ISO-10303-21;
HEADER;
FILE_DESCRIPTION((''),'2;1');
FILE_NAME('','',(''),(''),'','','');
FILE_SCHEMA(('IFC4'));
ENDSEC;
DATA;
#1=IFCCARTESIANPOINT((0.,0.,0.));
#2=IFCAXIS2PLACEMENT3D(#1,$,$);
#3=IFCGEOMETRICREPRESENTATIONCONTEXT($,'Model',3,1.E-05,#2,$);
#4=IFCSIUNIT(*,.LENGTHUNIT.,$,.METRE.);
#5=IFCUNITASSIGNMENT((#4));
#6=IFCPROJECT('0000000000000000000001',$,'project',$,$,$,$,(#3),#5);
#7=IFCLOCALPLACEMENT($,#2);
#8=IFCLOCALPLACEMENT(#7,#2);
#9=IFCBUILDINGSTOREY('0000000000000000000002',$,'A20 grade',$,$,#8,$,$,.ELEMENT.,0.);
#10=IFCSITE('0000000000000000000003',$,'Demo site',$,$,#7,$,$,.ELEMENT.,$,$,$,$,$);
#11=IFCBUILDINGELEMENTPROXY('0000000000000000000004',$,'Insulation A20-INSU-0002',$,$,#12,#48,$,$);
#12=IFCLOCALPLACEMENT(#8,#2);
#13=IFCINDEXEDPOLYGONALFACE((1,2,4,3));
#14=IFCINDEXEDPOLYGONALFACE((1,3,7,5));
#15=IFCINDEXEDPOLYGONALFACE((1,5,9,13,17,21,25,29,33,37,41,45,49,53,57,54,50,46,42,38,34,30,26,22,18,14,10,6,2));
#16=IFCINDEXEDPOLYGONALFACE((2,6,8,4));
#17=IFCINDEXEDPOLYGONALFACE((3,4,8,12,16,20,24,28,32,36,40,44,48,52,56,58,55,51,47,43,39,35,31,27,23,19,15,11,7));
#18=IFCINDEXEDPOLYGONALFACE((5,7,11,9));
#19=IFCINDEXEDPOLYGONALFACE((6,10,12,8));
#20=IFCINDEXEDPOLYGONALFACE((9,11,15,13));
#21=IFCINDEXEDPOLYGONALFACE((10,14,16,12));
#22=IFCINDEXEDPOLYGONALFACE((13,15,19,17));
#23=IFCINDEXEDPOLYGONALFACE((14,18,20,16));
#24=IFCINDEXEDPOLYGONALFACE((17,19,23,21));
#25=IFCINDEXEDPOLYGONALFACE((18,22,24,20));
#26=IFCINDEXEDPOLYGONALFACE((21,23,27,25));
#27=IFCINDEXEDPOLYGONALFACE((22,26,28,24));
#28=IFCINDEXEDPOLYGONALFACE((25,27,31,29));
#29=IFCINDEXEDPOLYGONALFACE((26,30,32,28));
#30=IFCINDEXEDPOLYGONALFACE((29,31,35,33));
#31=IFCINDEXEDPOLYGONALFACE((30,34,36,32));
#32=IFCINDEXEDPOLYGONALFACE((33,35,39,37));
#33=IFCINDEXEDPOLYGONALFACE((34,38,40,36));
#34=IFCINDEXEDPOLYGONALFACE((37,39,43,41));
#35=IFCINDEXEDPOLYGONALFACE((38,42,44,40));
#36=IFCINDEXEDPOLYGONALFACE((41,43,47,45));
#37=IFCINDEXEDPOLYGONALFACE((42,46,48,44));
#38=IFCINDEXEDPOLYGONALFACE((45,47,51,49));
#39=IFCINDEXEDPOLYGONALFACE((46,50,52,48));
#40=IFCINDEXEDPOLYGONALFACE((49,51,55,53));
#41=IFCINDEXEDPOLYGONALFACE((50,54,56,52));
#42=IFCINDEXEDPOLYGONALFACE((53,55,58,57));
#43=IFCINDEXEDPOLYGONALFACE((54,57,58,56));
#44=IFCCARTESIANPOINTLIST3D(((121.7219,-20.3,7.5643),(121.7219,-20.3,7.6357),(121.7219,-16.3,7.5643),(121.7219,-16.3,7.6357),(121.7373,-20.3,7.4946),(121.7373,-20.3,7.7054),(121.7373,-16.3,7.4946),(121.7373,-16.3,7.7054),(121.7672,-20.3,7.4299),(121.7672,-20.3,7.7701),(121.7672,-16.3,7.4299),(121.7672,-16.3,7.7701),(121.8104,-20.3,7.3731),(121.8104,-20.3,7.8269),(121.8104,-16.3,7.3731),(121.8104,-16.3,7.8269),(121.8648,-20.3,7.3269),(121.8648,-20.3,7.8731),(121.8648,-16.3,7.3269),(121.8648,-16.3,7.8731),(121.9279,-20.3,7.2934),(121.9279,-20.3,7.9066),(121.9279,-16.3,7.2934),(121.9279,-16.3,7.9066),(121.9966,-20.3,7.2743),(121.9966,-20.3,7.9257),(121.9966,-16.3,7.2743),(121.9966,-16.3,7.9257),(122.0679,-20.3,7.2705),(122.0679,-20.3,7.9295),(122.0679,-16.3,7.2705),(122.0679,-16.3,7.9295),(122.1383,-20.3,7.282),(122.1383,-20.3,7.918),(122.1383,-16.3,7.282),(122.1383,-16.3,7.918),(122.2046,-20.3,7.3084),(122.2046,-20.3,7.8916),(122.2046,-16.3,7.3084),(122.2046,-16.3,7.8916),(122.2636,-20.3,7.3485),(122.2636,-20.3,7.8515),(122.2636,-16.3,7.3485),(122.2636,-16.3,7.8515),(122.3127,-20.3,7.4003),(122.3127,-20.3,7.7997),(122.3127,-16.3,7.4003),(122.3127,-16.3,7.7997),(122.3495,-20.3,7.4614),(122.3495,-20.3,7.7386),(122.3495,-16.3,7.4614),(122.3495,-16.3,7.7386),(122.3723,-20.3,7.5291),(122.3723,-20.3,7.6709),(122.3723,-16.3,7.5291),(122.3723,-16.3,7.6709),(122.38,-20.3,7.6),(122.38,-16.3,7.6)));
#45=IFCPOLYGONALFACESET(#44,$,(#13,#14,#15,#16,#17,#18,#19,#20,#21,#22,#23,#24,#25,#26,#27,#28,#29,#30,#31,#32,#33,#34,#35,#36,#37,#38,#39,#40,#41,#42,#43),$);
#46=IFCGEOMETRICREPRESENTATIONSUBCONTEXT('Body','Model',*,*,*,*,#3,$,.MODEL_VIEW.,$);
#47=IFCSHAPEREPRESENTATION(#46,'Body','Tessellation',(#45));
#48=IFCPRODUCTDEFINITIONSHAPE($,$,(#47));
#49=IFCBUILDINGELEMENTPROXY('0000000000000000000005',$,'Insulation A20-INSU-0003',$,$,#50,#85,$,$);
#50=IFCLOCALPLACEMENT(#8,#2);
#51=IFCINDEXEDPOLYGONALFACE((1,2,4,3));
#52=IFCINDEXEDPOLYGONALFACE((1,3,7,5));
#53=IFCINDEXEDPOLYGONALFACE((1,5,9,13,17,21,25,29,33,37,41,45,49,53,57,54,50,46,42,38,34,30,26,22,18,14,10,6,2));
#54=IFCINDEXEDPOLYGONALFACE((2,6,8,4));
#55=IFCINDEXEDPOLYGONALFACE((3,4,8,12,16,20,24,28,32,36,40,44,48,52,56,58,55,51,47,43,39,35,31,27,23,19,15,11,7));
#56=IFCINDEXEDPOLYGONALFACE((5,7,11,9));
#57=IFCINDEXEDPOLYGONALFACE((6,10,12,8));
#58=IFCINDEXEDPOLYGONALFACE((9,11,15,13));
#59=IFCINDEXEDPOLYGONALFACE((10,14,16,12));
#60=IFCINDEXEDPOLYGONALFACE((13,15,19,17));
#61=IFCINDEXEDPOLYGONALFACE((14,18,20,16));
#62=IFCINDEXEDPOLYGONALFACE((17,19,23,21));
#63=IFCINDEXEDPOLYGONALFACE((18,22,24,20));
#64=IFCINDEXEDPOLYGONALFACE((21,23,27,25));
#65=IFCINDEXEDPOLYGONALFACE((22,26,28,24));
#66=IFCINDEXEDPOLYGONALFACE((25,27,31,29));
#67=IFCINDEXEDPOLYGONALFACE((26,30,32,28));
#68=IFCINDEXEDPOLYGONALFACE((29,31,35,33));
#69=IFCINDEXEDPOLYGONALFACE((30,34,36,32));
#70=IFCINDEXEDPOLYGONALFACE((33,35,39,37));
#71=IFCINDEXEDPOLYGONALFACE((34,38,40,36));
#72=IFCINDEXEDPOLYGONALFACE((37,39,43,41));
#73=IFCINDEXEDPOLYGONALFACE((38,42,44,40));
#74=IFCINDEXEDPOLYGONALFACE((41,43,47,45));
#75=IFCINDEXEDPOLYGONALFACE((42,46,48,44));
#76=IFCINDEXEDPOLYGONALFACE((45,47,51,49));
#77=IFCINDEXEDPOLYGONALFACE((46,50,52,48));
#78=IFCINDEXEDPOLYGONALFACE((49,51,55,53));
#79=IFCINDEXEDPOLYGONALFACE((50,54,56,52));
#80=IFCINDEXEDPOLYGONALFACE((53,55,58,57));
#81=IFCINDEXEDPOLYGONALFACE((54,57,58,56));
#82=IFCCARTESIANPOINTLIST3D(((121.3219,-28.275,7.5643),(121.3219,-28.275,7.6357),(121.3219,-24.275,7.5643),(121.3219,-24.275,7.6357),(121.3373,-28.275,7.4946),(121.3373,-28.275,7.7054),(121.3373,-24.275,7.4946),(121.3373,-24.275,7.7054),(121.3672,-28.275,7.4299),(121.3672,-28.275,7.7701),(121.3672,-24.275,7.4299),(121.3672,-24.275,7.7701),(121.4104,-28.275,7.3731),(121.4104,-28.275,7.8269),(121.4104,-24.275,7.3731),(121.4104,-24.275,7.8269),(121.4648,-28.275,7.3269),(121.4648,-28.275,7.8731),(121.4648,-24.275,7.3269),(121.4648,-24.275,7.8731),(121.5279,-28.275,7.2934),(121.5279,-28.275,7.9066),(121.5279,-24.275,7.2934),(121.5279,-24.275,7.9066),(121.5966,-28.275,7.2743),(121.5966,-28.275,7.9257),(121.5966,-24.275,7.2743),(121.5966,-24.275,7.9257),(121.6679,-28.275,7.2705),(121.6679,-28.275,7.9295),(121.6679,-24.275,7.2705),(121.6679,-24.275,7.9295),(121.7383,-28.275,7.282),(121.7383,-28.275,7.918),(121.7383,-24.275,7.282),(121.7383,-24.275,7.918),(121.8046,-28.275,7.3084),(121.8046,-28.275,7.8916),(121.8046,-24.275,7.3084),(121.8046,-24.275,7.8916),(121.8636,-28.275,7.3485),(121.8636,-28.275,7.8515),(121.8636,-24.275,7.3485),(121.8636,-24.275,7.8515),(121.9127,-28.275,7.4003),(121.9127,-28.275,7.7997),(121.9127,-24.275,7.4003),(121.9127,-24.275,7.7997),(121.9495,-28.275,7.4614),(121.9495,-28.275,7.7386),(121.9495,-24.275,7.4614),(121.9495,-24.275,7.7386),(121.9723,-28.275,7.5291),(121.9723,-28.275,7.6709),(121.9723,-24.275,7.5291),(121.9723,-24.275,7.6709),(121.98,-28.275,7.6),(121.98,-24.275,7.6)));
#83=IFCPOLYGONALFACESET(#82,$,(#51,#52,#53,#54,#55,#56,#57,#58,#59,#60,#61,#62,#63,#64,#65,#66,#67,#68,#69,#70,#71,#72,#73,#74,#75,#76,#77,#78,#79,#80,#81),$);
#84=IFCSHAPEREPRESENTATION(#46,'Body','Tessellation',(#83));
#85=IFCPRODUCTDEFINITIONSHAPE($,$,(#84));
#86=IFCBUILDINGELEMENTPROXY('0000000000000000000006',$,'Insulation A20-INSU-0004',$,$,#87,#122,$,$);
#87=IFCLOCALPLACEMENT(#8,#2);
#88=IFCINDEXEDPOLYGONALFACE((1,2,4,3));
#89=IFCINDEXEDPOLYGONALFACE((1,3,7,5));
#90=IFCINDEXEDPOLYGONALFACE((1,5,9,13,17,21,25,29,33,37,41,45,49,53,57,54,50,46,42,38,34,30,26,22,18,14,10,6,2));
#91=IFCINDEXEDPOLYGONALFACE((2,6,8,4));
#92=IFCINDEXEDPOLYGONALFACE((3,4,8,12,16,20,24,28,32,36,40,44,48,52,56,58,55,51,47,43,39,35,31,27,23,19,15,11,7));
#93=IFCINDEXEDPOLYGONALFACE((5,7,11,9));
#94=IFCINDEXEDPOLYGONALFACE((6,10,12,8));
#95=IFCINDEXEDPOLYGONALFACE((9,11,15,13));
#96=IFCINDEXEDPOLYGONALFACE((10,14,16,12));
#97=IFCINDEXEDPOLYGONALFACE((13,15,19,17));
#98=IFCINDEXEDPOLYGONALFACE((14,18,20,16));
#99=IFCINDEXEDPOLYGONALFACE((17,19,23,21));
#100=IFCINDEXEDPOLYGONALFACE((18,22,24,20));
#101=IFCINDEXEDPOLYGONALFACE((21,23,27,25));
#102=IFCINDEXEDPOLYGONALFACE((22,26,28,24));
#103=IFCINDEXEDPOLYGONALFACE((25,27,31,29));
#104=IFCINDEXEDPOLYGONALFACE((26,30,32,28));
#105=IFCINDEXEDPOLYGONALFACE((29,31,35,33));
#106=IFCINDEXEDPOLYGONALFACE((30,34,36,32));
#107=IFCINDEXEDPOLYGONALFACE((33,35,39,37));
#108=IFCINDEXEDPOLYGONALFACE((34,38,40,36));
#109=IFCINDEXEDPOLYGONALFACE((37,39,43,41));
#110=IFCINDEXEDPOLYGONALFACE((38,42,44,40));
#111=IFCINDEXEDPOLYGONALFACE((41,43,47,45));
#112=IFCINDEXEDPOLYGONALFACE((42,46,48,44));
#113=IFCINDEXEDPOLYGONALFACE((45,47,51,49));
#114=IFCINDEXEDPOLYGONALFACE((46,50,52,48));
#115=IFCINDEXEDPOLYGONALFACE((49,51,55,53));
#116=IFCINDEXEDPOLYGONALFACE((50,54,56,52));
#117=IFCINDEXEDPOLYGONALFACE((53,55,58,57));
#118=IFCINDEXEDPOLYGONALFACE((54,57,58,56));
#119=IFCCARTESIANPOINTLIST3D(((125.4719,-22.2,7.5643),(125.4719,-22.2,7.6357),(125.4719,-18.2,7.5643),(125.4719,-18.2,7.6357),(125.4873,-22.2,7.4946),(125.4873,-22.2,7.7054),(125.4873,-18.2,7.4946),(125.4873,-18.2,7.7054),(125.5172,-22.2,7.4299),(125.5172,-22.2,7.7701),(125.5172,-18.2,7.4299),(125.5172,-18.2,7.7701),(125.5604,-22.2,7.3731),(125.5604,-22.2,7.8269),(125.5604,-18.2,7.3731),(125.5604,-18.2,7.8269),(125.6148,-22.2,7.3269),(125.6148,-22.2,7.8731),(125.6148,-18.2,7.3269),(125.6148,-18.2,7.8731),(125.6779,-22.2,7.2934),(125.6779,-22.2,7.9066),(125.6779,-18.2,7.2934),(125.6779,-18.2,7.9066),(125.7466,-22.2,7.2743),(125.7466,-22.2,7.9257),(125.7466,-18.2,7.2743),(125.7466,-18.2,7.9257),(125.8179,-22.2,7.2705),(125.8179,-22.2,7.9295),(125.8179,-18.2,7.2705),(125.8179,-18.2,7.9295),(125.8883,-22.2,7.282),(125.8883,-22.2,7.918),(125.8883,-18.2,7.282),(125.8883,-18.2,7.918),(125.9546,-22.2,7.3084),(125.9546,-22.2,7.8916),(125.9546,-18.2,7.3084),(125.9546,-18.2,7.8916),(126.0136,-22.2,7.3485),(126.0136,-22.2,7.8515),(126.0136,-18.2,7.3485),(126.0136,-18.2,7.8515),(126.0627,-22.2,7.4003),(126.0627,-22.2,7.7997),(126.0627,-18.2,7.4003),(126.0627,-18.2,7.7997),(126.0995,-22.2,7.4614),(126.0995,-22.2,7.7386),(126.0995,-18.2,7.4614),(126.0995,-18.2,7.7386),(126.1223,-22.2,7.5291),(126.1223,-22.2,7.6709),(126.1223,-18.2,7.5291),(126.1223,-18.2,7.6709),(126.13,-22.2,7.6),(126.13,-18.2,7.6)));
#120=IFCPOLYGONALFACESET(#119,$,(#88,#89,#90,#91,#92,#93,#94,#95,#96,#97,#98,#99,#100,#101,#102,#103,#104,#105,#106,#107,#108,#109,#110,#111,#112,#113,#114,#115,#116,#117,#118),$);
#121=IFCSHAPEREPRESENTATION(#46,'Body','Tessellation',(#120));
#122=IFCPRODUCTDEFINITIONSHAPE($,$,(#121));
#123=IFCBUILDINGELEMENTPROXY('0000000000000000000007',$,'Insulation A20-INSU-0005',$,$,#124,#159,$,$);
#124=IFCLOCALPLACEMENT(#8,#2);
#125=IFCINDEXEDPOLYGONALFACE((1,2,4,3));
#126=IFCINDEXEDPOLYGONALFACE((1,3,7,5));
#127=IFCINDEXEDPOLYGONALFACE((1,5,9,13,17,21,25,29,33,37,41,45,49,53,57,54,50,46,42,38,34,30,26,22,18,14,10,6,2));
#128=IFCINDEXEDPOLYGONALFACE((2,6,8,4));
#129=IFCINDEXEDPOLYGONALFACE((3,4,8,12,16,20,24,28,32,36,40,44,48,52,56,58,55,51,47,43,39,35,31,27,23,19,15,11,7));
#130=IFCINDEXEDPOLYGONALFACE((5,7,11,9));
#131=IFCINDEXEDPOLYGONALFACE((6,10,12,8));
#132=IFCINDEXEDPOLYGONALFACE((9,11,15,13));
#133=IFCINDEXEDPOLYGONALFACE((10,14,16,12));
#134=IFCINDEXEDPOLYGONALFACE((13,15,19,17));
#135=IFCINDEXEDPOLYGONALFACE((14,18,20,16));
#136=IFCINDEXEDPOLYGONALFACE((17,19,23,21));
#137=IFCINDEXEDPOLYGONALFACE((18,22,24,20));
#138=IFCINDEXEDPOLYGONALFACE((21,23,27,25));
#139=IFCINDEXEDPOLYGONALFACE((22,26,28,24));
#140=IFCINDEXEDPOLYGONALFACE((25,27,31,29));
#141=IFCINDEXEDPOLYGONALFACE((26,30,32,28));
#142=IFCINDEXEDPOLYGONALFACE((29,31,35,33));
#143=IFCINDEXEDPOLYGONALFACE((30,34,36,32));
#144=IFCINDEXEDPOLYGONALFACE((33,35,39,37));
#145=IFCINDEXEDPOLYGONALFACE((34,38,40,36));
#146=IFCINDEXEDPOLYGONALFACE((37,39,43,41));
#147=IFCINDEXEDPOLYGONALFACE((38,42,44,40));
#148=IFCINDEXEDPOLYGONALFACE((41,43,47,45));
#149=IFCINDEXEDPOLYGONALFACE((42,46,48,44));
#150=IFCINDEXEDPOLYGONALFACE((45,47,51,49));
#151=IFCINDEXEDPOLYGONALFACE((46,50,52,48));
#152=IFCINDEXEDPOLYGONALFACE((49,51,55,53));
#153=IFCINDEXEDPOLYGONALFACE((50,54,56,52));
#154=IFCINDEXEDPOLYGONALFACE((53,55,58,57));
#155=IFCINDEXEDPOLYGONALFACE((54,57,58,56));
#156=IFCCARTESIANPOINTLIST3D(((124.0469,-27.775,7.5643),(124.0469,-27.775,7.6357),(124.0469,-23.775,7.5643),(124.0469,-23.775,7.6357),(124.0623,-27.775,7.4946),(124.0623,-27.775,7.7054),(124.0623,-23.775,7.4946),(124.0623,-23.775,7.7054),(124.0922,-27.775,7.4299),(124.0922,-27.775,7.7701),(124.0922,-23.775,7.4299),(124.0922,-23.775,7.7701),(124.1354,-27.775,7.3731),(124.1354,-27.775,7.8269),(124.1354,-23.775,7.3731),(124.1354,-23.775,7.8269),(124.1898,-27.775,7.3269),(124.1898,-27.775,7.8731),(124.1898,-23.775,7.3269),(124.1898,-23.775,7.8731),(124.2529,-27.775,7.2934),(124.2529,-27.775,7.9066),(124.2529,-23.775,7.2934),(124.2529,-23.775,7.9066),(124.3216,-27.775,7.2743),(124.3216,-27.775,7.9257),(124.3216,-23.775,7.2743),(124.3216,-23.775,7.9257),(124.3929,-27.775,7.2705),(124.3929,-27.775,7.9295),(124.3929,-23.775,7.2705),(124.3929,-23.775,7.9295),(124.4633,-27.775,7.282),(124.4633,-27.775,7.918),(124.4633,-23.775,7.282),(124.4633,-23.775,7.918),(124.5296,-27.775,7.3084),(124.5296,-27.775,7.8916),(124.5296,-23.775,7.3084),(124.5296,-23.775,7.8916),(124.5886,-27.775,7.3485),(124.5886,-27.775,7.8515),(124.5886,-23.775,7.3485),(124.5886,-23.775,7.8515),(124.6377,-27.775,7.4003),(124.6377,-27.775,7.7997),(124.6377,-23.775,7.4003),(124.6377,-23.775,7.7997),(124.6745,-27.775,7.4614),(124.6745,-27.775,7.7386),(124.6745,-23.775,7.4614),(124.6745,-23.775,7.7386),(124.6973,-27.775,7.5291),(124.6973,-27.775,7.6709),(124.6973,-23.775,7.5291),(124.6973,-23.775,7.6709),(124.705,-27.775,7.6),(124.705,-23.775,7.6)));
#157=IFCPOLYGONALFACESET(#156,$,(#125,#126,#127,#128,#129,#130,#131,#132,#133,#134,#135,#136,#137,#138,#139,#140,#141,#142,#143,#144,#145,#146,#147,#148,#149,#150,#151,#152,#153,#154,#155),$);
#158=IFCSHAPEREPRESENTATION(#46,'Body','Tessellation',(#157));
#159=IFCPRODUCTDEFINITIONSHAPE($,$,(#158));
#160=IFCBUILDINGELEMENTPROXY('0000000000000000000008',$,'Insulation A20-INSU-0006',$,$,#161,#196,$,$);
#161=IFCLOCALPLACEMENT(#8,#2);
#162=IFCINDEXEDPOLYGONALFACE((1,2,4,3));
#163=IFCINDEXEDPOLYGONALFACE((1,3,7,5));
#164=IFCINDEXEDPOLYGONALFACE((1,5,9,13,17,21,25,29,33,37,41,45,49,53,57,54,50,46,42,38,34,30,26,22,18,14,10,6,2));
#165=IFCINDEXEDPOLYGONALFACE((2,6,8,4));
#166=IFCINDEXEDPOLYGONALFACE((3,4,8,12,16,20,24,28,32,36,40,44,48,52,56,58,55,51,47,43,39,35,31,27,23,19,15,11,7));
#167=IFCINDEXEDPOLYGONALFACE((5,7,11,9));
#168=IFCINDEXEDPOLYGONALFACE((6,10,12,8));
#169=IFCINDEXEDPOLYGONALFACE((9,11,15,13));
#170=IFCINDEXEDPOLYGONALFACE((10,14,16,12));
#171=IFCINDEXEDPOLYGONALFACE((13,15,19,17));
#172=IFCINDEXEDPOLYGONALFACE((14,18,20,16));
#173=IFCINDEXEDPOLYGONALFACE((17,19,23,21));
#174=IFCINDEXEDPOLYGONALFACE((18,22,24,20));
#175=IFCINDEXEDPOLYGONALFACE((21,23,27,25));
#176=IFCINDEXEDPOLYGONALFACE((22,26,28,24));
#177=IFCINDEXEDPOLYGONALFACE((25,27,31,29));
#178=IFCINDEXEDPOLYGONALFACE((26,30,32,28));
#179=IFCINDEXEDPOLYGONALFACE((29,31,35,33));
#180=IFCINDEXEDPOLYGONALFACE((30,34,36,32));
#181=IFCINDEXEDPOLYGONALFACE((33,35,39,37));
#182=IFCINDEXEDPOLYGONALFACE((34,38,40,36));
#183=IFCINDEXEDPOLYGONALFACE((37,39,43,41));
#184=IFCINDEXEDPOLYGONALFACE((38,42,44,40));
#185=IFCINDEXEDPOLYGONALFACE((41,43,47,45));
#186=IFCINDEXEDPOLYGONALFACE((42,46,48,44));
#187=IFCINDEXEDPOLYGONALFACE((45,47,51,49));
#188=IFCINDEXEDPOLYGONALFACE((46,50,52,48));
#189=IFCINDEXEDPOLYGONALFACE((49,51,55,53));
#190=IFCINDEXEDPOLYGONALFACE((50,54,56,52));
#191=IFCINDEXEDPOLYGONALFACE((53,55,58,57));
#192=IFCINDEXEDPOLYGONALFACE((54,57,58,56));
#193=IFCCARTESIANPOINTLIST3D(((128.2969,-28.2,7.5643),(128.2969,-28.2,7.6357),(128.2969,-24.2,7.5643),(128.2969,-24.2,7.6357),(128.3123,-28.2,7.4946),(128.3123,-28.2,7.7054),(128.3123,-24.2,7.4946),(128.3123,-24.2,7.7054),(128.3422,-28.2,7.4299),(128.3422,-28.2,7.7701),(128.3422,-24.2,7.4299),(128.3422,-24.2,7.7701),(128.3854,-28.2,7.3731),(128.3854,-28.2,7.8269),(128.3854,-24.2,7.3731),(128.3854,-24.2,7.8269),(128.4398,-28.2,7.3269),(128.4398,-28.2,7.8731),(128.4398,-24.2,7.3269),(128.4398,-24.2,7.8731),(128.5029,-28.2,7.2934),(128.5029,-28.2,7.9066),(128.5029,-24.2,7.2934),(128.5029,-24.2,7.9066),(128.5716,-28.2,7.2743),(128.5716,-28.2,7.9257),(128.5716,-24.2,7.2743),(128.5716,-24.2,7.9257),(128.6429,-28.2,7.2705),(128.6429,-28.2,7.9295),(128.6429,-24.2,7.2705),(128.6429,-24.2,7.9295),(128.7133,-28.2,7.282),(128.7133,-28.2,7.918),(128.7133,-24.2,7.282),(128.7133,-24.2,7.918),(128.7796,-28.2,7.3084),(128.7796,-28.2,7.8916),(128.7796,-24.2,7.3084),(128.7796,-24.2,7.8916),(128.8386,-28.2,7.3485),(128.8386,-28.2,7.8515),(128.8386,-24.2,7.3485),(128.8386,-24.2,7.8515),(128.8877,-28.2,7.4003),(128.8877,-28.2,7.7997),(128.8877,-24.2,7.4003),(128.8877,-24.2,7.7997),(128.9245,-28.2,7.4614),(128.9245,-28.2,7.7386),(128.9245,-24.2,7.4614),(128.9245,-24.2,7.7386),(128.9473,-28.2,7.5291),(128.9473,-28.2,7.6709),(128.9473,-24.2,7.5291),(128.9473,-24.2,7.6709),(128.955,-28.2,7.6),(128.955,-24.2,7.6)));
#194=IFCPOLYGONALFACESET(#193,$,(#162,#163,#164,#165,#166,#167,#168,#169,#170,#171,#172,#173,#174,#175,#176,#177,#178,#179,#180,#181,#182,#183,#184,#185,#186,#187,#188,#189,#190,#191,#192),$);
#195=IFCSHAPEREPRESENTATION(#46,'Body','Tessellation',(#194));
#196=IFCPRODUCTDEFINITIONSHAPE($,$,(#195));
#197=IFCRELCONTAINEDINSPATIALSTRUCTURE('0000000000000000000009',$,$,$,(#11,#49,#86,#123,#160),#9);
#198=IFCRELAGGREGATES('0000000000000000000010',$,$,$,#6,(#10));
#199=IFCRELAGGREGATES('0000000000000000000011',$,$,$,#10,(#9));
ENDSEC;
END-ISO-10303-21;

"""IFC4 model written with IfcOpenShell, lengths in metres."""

from ifc_helpers import new_model, si_unit, frame, origin, place, context, subcontext, project, spatial, circle, extrude, element, save


model = new_model("IFC4")

# Units and contexts
model_context = context("Model", 3, precision=1e-05, world=origin())
body_context = subcontext(model_context, "Body", "Model", "MODEL_VIEW")
ifc_project = project(units=[si_unit("LENGTHUNIT", "METRE")], contexts=[model_context])

# Site, storey
site_placement = place(None, origin())
site = spatial("IfcSite", under=ifc_project, at=site_placement, Name="Demo site", CompositionType="ELEMENT")
storey_placement = place(site_placement, origin())
storey = spatial("IfcBuildingStorey", under=site, at=storey_placement, Name="A20 grade", CompositionType="ELEMENT", Elevation=0.0)

# Building element proxies
for number, where, name in (
    (1, (122.05, -20.3, 7.6), "Insulation A20-INSU-0002"),
    (2, (121.65, -28.275, 7.6), "Insulation A20-INSU-0003"),
    (3, (125.8, -22.2, 7.6), "Insulation A20-INSU-0004"),
    (4, (124.375, -27.775, 7.6), "Insulation A20-INSU-0005"),
    (5, (128.625, -28.2, 7.6), "Insulation A20-INSU-0006"),
):
    element("IfcBuildingElementProxy", number, at=place(storey_placement, frame(where)), inside=storey, Name=name, context=body_context, shape_type="SweptSolid", body=[
        extrude(circle(Radius=0.33), frame((0.0, 0.0, 0.0), z_axis=(0.0, 1.0, 0.0), x_axis=(1.0, 0.0, 0.0)), (0.0, 0.0, 1.0), 4.0),
    ])

save(model, "model.ifc")
